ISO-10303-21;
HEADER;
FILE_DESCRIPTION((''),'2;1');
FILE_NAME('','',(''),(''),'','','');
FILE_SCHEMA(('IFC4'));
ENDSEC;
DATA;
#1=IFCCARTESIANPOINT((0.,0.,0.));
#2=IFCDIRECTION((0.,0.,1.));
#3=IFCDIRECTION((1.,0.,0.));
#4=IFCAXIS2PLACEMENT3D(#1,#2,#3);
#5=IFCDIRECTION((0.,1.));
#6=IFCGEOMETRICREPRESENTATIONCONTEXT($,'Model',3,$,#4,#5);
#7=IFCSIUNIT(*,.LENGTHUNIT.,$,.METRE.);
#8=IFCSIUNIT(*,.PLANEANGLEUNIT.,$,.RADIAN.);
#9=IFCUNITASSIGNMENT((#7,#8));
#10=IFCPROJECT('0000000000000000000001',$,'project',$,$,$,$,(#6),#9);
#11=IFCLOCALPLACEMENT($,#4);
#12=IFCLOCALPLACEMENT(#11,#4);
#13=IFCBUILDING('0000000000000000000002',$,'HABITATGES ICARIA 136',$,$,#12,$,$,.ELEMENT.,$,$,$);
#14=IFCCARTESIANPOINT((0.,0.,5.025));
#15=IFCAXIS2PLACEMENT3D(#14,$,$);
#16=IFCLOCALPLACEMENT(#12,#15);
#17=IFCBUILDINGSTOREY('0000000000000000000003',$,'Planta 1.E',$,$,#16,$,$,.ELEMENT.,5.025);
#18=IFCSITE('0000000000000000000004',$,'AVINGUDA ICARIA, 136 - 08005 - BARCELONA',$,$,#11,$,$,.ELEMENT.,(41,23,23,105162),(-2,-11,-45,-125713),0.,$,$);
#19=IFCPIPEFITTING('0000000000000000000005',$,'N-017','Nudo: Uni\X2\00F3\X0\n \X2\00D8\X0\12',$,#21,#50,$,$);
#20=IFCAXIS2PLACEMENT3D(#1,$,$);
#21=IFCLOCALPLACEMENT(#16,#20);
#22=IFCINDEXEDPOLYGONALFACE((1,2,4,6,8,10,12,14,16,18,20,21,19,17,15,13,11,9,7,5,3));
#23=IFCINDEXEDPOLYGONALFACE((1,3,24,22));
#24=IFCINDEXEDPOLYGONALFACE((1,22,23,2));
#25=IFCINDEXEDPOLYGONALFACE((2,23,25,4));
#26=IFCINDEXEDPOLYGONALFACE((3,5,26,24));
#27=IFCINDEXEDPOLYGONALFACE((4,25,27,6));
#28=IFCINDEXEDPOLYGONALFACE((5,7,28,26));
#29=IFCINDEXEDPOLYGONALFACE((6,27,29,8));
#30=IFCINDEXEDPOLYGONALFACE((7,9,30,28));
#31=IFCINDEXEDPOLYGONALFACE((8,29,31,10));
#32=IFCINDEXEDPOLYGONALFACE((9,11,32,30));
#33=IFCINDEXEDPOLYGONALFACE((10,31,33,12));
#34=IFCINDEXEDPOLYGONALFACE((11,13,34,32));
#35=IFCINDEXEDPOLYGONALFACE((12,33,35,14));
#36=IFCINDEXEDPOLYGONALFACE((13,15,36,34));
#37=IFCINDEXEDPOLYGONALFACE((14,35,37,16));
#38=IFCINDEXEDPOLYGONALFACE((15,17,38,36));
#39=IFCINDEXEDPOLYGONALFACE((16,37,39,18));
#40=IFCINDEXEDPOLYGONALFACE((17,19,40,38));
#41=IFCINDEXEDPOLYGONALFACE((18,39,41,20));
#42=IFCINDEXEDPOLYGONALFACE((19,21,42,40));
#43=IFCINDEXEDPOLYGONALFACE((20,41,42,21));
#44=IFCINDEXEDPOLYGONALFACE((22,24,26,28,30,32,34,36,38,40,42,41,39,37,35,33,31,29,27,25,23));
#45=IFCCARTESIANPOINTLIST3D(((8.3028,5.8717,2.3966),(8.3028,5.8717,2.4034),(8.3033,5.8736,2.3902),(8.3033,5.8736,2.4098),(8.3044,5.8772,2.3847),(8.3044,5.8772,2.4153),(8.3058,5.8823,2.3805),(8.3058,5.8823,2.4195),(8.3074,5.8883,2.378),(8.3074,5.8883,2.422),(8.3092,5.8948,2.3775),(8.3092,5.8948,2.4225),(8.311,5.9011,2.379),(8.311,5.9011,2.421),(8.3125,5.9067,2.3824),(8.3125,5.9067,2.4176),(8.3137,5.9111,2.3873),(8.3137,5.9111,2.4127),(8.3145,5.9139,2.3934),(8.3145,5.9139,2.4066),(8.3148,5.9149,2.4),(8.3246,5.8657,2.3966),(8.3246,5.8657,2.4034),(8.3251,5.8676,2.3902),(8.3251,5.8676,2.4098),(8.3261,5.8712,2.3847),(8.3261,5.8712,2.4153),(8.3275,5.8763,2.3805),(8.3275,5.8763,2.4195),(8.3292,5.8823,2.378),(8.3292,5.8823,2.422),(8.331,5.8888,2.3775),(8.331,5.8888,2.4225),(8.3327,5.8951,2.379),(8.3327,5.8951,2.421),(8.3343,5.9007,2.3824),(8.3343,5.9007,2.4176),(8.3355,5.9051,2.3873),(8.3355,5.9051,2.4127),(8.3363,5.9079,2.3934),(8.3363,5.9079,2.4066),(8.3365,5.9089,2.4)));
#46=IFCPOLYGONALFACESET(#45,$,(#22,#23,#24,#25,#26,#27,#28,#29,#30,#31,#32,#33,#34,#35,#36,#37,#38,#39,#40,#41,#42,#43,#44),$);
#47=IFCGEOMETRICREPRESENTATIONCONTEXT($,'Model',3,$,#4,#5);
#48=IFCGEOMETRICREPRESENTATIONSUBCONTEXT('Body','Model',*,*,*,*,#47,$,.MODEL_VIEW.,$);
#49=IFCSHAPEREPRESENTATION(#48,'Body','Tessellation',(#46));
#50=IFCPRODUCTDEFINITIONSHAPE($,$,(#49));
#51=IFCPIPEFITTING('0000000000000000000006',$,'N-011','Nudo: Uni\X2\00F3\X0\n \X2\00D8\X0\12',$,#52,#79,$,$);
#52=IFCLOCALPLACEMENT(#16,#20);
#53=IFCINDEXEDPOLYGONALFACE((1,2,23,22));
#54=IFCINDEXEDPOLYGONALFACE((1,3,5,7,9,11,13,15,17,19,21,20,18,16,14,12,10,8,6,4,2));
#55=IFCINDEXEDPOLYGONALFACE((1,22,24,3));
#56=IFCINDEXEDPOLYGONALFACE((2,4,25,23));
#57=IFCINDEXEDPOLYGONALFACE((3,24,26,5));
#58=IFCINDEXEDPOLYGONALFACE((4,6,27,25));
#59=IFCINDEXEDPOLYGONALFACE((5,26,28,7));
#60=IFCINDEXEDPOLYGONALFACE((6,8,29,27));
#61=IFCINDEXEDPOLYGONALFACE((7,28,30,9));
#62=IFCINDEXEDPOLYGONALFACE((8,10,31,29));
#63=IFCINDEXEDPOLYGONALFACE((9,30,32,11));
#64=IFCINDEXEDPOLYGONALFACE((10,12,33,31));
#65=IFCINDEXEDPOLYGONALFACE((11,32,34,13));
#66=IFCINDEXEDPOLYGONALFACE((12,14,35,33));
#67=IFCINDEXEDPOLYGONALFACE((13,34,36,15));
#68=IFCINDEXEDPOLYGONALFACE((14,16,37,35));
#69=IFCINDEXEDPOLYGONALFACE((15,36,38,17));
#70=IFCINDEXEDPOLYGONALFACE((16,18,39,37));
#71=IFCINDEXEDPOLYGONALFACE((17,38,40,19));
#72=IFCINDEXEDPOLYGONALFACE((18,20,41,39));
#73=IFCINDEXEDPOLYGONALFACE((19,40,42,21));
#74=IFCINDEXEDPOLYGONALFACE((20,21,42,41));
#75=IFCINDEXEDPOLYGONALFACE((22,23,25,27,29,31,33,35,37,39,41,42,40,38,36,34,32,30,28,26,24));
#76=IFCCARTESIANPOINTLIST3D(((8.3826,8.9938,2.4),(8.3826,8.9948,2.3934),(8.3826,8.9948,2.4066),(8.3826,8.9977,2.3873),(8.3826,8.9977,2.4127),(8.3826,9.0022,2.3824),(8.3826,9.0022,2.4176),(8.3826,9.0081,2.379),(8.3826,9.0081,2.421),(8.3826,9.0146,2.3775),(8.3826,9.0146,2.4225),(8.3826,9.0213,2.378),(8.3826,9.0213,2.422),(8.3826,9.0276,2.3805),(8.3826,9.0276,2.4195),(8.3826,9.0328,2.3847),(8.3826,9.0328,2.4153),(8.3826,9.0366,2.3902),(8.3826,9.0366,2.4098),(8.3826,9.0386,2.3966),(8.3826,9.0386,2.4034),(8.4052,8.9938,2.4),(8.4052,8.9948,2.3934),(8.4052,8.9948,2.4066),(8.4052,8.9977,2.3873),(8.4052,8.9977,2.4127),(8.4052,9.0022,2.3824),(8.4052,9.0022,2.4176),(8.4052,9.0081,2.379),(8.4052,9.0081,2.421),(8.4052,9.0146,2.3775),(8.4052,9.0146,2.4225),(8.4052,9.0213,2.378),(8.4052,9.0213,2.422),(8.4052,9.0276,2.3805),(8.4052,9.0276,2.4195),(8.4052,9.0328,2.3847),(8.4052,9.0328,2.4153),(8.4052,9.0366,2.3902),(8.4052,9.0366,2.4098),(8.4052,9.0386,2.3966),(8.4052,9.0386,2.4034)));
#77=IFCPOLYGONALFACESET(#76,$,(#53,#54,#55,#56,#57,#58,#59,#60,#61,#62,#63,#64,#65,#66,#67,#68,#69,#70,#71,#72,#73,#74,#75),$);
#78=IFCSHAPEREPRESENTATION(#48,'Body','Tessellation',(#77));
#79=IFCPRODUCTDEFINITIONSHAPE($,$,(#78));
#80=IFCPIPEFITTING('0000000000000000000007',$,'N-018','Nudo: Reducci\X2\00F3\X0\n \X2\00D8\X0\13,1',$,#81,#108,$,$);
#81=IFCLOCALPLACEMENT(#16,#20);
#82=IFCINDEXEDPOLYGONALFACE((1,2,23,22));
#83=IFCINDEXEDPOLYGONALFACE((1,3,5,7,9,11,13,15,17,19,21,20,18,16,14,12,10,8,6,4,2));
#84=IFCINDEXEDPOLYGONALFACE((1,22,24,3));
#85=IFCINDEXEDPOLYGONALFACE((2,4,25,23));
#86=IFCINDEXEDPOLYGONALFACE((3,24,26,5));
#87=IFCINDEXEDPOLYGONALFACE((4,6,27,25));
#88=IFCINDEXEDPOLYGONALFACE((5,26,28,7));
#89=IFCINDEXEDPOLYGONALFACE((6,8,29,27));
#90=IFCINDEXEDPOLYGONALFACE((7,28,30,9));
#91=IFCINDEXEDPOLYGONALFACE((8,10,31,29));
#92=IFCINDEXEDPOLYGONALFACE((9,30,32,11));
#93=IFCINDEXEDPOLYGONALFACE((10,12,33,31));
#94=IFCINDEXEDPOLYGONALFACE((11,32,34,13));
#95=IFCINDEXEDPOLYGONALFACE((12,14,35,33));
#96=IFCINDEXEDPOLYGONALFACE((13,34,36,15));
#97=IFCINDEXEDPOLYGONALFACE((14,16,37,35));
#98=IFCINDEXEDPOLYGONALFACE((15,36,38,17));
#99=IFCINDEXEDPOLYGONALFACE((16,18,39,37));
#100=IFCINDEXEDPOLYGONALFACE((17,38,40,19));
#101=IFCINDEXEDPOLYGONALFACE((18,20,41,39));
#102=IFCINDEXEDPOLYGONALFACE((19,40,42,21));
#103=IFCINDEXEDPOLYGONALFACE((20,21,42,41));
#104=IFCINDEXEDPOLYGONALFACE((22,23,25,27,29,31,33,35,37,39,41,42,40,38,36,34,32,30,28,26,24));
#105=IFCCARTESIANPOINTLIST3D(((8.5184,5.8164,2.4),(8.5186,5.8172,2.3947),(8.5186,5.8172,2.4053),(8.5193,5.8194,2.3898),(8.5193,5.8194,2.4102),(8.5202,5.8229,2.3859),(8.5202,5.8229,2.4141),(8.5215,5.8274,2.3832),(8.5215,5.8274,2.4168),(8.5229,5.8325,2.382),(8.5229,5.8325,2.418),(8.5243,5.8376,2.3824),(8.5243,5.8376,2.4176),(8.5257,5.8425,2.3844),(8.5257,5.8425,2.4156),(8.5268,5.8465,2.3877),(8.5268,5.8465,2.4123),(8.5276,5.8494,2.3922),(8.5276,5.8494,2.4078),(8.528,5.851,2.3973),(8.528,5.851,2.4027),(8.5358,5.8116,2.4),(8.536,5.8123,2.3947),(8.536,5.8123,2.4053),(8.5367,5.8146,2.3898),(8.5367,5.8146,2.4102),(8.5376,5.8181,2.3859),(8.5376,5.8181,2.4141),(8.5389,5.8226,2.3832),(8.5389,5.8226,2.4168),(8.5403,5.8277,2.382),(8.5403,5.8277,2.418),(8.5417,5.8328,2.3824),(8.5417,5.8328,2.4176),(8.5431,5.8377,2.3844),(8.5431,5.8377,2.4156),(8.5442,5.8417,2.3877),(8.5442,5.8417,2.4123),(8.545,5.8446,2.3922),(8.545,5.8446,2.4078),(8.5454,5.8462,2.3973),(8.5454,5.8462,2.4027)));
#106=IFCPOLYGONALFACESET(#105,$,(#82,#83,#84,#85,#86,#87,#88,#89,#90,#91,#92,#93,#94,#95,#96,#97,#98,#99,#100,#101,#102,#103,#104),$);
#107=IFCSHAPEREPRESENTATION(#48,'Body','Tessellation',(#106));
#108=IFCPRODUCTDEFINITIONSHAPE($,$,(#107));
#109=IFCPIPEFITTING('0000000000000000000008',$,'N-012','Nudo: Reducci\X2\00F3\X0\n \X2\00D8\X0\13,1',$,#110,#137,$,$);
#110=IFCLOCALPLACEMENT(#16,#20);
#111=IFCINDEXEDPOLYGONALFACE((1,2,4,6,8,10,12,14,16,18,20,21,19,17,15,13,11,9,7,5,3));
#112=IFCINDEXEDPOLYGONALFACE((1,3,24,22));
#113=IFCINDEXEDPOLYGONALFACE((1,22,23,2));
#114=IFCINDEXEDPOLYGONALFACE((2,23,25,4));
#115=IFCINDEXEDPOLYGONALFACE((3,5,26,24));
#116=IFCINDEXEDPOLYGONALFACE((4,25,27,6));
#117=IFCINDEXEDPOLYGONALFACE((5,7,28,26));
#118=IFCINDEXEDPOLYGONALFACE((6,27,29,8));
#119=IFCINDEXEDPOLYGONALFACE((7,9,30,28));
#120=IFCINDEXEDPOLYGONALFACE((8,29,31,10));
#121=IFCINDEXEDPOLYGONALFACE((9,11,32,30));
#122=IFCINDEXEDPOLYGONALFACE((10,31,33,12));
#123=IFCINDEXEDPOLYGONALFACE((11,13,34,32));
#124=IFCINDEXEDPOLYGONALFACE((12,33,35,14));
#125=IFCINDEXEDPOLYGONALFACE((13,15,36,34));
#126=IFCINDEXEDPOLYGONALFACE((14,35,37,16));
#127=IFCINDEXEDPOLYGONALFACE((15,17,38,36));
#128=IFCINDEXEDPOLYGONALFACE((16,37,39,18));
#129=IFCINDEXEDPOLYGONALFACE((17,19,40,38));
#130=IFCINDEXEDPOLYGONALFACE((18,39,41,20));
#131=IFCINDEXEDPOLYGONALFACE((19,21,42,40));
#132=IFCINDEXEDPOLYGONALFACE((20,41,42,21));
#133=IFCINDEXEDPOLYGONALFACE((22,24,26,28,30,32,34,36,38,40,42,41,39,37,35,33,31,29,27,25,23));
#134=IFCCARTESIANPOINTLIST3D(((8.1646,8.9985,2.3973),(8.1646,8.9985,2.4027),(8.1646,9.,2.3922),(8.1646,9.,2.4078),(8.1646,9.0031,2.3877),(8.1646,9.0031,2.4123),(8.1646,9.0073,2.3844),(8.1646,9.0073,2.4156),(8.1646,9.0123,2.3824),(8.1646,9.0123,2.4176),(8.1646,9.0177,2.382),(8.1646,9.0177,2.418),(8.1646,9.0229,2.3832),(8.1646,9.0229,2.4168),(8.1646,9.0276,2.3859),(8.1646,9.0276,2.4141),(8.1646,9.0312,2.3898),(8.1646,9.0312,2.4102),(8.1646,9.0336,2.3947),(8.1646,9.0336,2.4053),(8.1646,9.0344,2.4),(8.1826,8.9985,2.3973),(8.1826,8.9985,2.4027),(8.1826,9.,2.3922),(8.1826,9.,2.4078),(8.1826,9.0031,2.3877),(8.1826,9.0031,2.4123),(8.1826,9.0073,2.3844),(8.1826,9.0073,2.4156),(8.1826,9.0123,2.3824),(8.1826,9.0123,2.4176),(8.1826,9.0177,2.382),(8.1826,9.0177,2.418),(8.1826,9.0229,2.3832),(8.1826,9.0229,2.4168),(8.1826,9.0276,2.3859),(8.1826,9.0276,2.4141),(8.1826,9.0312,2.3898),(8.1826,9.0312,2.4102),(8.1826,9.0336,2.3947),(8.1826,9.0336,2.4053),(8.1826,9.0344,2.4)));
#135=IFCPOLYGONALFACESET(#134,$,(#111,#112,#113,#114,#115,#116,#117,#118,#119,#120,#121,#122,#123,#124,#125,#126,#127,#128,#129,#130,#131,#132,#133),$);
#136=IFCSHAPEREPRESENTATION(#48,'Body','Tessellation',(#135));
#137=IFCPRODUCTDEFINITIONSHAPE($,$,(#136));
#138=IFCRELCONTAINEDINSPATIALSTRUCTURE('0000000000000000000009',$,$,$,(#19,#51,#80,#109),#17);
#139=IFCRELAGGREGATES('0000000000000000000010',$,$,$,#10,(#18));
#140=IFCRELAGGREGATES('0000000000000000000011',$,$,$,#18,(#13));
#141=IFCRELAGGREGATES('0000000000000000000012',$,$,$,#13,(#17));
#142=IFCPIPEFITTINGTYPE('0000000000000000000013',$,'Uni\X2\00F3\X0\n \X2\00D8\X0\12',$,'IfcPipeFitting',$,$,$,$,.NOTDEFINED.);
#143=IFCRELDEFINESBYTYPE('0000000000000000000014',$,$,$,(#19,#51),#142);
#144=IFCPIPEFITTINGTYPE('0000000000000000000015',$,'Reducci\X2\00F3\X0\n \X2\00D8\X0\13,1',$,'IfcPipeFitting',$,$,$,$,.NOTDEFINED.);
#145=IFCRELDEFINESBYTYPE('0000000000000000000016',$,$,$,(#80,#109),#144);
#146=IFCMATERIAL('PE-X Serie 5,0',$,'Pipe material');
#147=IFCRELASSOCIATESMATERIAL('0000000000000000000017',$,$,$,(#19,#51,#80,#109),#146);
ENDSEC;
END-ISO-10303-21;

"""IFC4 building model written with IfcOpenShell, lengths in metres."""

from ifc_helpers import new_model, si_unit, direction, frame, origin_with_axes, origin_2d_with_axis, place, context, subcontext, project, spatial, circle, extrude, source, transform, mapped, material, type_object, element, save


model = new_model("IFC4")

# Units and contexts
model_context_1 = context("Model", 3, world=origin_with_axes(), true_north=direction((0.0, 1.0)))
model_context_2 = context("Model", 3, world=origin_with_axes(), true_north=direction((0.0, 1.0)))
body_context_1 = subcontext(model_context_2, "Body", "Model", "MODEL_VIEW")
ifc_project = project(units=[si_unit("LENGTHUNIT", "METRE"), si_unit("PLANEANGLEUNIT", "RADIAN")], contexts=[model_context_1])

# Site, building, storey
site_placement = place(None, origin_with_axes())
site = spatial("IfcSite", under=ifc_project, at=site_placement, Name="AVINGUDA ICARIA, 136 - 08005 - BARCELONA", CompositionType="ELEMENT", RefLatitude=(41, 23, 23, 105162), RefLongitude=(-2, -11, -45, -125713), RefElevation=0.0)
building_placement = place(site_placement, origin_with_axes())
building = spatial("IfcBuilding", under=site, at=building_placement, Name="HABITATGES ICARIA 136", CompositionType="ELEMENT")
storey_placement = place(building_placement, frame((0.0, 0.0, 5.025)))
storey = spatial("IfcBuildingStorey", under=building, at=storey_placement, Name="Planta 1.E", CompositionType="ELEMENT", Elevation=5.025)

# Pipe fittings
ifc_material_1 = material(Name="PE-X Serie 5,0", Category="Pipe material")
pipe_fitting_type_1 = type_object("IfcPipeFittingType", Name="Unión Ø12", ApplicableOccurrence="IfcPipeFitting", PredefinedType="NOTDEFINED")
shared_shape_1 = source(origin_with_axes(), body_context_1, "Body", "SweptSolid", [
    extrude(circle(Radius=0.0226, at=origin_2d_with_axis()), frame((0.0, -0.0226, 0.0), z_axis=(0.0, 1.0, 0.0), x_axis=(-1.0, 0.0, 0.0)), (0.0, 0.0, 1.0), 0.0226),
])
placement_1 = place(None, origin_with_axes())
placement_2 = place(placement_1, origin_with_axes())
placement_3 = place(placement_2, frame((0.0, 0.0, 5.025)))
pipe_fitting_1_placement = place(placement_3, origin_with_axes())
element("IfcPipeFitting", 1, at=pipe_fitting_1_placement, inside=storey, type_object=pipe_fitting_type_1, material=ifc_material_1, Name="N-017", Description="Nudo: Unión Ø12", context=body_context_1, shape_type="MappedRepresentation", body=[
    mapped(shared_shape_1, transform((8.3305, 5.8871, 2.4), x_axis=(-0.266843, -0.96374, 0.0), y_axis=(0.96374, -0.266843, 0.0), z_axis=(0.0, 0.0, 1.0), scale=1.0)),
])
pipe_fitting_2_placement = place(placement_3, origin_with_axes())
element("IfcPipeFitting", 2, at=pipe_fitting_2_placement, inside=storey, type_object=pipe_fitting_type_1, material=ifc_material_1, Name="N-011", Description="Nudo: Unión Ø12", context=body_context_1, shape_type="MappedRepresentation", body=[
    mapped(shared_shape_1, transform((8.3826, 9.0163, 2.4), x_axis=(0.0, 1.0, 0.0), y_axis=(-1.0, 0.0, 0.0), z_axis=(0.0, 0.0, 1.0), scale=1.0)),
])
pipe_fitting_type_2 = type_object("IfcPipeFittingType", Name="Reducción Ø13,1", ApplicableOccurrence="IfcPipeFitting", PredefinedType="NOTDEFINED")
shared_shape_2 = source(origin_with_axes(), body_context_1, "Body", "SweptSolid", [
    extrude(circle(Radius=0.0181, at=origin_2d_with_axis()), frame((0.0, -0.0181, 0.0), z_axis=(0.0, 1.0, 0.0), x_axis=(-1.0, 0.0, 0.0)), (0.0, 0.0, 1.0), 0.0181),
])
pipe_fitting_3_placement = place(placement_3, origin_with_axes())
element("IfcPipeFitting", 3, at=pipe_fitting_3_placement, inside=storey, type_object=pipe_fitting_type_2, material=ifc_material_1, Name="N-018", Description="Nudo: Reducción Ø13,1", context=body_context_1, shape_type="MappedRepresentation", body=[
    mapped(shared_shape_2, transform((8.5233, 5.8338, 2.4), x_axis=(0.266843, 0.96374, 0.0), y_axis=(-0.96374, 0.266843, 0.0), z_axis=(0.0, 0.0, 1.0), scale=1.0)),
])
pipe_fitting_4_placement = place(placement_3, origin_with_axes())
element("IfcPipeFitting", 4, at=pipe_fitting_4_placement, inside=storey, type_object=pipe_fitting_type_2, material=ifc_material_1, Name="N-012", Description="Nudo: Reducción Ø13,1", context=body_context_1, shape_type="MappedRepresentation", body=[
    mapped(shared_shape_2, transform((8.1826, 9.0163, 2.4), x_axis=(0.0, -1.0, 0.0), y_axis=(1.0, 0.0, 0.0), z_axis=(0.0, 0.0, 1.0), scale=1.0)),
])

save(model, "model.ifc")
